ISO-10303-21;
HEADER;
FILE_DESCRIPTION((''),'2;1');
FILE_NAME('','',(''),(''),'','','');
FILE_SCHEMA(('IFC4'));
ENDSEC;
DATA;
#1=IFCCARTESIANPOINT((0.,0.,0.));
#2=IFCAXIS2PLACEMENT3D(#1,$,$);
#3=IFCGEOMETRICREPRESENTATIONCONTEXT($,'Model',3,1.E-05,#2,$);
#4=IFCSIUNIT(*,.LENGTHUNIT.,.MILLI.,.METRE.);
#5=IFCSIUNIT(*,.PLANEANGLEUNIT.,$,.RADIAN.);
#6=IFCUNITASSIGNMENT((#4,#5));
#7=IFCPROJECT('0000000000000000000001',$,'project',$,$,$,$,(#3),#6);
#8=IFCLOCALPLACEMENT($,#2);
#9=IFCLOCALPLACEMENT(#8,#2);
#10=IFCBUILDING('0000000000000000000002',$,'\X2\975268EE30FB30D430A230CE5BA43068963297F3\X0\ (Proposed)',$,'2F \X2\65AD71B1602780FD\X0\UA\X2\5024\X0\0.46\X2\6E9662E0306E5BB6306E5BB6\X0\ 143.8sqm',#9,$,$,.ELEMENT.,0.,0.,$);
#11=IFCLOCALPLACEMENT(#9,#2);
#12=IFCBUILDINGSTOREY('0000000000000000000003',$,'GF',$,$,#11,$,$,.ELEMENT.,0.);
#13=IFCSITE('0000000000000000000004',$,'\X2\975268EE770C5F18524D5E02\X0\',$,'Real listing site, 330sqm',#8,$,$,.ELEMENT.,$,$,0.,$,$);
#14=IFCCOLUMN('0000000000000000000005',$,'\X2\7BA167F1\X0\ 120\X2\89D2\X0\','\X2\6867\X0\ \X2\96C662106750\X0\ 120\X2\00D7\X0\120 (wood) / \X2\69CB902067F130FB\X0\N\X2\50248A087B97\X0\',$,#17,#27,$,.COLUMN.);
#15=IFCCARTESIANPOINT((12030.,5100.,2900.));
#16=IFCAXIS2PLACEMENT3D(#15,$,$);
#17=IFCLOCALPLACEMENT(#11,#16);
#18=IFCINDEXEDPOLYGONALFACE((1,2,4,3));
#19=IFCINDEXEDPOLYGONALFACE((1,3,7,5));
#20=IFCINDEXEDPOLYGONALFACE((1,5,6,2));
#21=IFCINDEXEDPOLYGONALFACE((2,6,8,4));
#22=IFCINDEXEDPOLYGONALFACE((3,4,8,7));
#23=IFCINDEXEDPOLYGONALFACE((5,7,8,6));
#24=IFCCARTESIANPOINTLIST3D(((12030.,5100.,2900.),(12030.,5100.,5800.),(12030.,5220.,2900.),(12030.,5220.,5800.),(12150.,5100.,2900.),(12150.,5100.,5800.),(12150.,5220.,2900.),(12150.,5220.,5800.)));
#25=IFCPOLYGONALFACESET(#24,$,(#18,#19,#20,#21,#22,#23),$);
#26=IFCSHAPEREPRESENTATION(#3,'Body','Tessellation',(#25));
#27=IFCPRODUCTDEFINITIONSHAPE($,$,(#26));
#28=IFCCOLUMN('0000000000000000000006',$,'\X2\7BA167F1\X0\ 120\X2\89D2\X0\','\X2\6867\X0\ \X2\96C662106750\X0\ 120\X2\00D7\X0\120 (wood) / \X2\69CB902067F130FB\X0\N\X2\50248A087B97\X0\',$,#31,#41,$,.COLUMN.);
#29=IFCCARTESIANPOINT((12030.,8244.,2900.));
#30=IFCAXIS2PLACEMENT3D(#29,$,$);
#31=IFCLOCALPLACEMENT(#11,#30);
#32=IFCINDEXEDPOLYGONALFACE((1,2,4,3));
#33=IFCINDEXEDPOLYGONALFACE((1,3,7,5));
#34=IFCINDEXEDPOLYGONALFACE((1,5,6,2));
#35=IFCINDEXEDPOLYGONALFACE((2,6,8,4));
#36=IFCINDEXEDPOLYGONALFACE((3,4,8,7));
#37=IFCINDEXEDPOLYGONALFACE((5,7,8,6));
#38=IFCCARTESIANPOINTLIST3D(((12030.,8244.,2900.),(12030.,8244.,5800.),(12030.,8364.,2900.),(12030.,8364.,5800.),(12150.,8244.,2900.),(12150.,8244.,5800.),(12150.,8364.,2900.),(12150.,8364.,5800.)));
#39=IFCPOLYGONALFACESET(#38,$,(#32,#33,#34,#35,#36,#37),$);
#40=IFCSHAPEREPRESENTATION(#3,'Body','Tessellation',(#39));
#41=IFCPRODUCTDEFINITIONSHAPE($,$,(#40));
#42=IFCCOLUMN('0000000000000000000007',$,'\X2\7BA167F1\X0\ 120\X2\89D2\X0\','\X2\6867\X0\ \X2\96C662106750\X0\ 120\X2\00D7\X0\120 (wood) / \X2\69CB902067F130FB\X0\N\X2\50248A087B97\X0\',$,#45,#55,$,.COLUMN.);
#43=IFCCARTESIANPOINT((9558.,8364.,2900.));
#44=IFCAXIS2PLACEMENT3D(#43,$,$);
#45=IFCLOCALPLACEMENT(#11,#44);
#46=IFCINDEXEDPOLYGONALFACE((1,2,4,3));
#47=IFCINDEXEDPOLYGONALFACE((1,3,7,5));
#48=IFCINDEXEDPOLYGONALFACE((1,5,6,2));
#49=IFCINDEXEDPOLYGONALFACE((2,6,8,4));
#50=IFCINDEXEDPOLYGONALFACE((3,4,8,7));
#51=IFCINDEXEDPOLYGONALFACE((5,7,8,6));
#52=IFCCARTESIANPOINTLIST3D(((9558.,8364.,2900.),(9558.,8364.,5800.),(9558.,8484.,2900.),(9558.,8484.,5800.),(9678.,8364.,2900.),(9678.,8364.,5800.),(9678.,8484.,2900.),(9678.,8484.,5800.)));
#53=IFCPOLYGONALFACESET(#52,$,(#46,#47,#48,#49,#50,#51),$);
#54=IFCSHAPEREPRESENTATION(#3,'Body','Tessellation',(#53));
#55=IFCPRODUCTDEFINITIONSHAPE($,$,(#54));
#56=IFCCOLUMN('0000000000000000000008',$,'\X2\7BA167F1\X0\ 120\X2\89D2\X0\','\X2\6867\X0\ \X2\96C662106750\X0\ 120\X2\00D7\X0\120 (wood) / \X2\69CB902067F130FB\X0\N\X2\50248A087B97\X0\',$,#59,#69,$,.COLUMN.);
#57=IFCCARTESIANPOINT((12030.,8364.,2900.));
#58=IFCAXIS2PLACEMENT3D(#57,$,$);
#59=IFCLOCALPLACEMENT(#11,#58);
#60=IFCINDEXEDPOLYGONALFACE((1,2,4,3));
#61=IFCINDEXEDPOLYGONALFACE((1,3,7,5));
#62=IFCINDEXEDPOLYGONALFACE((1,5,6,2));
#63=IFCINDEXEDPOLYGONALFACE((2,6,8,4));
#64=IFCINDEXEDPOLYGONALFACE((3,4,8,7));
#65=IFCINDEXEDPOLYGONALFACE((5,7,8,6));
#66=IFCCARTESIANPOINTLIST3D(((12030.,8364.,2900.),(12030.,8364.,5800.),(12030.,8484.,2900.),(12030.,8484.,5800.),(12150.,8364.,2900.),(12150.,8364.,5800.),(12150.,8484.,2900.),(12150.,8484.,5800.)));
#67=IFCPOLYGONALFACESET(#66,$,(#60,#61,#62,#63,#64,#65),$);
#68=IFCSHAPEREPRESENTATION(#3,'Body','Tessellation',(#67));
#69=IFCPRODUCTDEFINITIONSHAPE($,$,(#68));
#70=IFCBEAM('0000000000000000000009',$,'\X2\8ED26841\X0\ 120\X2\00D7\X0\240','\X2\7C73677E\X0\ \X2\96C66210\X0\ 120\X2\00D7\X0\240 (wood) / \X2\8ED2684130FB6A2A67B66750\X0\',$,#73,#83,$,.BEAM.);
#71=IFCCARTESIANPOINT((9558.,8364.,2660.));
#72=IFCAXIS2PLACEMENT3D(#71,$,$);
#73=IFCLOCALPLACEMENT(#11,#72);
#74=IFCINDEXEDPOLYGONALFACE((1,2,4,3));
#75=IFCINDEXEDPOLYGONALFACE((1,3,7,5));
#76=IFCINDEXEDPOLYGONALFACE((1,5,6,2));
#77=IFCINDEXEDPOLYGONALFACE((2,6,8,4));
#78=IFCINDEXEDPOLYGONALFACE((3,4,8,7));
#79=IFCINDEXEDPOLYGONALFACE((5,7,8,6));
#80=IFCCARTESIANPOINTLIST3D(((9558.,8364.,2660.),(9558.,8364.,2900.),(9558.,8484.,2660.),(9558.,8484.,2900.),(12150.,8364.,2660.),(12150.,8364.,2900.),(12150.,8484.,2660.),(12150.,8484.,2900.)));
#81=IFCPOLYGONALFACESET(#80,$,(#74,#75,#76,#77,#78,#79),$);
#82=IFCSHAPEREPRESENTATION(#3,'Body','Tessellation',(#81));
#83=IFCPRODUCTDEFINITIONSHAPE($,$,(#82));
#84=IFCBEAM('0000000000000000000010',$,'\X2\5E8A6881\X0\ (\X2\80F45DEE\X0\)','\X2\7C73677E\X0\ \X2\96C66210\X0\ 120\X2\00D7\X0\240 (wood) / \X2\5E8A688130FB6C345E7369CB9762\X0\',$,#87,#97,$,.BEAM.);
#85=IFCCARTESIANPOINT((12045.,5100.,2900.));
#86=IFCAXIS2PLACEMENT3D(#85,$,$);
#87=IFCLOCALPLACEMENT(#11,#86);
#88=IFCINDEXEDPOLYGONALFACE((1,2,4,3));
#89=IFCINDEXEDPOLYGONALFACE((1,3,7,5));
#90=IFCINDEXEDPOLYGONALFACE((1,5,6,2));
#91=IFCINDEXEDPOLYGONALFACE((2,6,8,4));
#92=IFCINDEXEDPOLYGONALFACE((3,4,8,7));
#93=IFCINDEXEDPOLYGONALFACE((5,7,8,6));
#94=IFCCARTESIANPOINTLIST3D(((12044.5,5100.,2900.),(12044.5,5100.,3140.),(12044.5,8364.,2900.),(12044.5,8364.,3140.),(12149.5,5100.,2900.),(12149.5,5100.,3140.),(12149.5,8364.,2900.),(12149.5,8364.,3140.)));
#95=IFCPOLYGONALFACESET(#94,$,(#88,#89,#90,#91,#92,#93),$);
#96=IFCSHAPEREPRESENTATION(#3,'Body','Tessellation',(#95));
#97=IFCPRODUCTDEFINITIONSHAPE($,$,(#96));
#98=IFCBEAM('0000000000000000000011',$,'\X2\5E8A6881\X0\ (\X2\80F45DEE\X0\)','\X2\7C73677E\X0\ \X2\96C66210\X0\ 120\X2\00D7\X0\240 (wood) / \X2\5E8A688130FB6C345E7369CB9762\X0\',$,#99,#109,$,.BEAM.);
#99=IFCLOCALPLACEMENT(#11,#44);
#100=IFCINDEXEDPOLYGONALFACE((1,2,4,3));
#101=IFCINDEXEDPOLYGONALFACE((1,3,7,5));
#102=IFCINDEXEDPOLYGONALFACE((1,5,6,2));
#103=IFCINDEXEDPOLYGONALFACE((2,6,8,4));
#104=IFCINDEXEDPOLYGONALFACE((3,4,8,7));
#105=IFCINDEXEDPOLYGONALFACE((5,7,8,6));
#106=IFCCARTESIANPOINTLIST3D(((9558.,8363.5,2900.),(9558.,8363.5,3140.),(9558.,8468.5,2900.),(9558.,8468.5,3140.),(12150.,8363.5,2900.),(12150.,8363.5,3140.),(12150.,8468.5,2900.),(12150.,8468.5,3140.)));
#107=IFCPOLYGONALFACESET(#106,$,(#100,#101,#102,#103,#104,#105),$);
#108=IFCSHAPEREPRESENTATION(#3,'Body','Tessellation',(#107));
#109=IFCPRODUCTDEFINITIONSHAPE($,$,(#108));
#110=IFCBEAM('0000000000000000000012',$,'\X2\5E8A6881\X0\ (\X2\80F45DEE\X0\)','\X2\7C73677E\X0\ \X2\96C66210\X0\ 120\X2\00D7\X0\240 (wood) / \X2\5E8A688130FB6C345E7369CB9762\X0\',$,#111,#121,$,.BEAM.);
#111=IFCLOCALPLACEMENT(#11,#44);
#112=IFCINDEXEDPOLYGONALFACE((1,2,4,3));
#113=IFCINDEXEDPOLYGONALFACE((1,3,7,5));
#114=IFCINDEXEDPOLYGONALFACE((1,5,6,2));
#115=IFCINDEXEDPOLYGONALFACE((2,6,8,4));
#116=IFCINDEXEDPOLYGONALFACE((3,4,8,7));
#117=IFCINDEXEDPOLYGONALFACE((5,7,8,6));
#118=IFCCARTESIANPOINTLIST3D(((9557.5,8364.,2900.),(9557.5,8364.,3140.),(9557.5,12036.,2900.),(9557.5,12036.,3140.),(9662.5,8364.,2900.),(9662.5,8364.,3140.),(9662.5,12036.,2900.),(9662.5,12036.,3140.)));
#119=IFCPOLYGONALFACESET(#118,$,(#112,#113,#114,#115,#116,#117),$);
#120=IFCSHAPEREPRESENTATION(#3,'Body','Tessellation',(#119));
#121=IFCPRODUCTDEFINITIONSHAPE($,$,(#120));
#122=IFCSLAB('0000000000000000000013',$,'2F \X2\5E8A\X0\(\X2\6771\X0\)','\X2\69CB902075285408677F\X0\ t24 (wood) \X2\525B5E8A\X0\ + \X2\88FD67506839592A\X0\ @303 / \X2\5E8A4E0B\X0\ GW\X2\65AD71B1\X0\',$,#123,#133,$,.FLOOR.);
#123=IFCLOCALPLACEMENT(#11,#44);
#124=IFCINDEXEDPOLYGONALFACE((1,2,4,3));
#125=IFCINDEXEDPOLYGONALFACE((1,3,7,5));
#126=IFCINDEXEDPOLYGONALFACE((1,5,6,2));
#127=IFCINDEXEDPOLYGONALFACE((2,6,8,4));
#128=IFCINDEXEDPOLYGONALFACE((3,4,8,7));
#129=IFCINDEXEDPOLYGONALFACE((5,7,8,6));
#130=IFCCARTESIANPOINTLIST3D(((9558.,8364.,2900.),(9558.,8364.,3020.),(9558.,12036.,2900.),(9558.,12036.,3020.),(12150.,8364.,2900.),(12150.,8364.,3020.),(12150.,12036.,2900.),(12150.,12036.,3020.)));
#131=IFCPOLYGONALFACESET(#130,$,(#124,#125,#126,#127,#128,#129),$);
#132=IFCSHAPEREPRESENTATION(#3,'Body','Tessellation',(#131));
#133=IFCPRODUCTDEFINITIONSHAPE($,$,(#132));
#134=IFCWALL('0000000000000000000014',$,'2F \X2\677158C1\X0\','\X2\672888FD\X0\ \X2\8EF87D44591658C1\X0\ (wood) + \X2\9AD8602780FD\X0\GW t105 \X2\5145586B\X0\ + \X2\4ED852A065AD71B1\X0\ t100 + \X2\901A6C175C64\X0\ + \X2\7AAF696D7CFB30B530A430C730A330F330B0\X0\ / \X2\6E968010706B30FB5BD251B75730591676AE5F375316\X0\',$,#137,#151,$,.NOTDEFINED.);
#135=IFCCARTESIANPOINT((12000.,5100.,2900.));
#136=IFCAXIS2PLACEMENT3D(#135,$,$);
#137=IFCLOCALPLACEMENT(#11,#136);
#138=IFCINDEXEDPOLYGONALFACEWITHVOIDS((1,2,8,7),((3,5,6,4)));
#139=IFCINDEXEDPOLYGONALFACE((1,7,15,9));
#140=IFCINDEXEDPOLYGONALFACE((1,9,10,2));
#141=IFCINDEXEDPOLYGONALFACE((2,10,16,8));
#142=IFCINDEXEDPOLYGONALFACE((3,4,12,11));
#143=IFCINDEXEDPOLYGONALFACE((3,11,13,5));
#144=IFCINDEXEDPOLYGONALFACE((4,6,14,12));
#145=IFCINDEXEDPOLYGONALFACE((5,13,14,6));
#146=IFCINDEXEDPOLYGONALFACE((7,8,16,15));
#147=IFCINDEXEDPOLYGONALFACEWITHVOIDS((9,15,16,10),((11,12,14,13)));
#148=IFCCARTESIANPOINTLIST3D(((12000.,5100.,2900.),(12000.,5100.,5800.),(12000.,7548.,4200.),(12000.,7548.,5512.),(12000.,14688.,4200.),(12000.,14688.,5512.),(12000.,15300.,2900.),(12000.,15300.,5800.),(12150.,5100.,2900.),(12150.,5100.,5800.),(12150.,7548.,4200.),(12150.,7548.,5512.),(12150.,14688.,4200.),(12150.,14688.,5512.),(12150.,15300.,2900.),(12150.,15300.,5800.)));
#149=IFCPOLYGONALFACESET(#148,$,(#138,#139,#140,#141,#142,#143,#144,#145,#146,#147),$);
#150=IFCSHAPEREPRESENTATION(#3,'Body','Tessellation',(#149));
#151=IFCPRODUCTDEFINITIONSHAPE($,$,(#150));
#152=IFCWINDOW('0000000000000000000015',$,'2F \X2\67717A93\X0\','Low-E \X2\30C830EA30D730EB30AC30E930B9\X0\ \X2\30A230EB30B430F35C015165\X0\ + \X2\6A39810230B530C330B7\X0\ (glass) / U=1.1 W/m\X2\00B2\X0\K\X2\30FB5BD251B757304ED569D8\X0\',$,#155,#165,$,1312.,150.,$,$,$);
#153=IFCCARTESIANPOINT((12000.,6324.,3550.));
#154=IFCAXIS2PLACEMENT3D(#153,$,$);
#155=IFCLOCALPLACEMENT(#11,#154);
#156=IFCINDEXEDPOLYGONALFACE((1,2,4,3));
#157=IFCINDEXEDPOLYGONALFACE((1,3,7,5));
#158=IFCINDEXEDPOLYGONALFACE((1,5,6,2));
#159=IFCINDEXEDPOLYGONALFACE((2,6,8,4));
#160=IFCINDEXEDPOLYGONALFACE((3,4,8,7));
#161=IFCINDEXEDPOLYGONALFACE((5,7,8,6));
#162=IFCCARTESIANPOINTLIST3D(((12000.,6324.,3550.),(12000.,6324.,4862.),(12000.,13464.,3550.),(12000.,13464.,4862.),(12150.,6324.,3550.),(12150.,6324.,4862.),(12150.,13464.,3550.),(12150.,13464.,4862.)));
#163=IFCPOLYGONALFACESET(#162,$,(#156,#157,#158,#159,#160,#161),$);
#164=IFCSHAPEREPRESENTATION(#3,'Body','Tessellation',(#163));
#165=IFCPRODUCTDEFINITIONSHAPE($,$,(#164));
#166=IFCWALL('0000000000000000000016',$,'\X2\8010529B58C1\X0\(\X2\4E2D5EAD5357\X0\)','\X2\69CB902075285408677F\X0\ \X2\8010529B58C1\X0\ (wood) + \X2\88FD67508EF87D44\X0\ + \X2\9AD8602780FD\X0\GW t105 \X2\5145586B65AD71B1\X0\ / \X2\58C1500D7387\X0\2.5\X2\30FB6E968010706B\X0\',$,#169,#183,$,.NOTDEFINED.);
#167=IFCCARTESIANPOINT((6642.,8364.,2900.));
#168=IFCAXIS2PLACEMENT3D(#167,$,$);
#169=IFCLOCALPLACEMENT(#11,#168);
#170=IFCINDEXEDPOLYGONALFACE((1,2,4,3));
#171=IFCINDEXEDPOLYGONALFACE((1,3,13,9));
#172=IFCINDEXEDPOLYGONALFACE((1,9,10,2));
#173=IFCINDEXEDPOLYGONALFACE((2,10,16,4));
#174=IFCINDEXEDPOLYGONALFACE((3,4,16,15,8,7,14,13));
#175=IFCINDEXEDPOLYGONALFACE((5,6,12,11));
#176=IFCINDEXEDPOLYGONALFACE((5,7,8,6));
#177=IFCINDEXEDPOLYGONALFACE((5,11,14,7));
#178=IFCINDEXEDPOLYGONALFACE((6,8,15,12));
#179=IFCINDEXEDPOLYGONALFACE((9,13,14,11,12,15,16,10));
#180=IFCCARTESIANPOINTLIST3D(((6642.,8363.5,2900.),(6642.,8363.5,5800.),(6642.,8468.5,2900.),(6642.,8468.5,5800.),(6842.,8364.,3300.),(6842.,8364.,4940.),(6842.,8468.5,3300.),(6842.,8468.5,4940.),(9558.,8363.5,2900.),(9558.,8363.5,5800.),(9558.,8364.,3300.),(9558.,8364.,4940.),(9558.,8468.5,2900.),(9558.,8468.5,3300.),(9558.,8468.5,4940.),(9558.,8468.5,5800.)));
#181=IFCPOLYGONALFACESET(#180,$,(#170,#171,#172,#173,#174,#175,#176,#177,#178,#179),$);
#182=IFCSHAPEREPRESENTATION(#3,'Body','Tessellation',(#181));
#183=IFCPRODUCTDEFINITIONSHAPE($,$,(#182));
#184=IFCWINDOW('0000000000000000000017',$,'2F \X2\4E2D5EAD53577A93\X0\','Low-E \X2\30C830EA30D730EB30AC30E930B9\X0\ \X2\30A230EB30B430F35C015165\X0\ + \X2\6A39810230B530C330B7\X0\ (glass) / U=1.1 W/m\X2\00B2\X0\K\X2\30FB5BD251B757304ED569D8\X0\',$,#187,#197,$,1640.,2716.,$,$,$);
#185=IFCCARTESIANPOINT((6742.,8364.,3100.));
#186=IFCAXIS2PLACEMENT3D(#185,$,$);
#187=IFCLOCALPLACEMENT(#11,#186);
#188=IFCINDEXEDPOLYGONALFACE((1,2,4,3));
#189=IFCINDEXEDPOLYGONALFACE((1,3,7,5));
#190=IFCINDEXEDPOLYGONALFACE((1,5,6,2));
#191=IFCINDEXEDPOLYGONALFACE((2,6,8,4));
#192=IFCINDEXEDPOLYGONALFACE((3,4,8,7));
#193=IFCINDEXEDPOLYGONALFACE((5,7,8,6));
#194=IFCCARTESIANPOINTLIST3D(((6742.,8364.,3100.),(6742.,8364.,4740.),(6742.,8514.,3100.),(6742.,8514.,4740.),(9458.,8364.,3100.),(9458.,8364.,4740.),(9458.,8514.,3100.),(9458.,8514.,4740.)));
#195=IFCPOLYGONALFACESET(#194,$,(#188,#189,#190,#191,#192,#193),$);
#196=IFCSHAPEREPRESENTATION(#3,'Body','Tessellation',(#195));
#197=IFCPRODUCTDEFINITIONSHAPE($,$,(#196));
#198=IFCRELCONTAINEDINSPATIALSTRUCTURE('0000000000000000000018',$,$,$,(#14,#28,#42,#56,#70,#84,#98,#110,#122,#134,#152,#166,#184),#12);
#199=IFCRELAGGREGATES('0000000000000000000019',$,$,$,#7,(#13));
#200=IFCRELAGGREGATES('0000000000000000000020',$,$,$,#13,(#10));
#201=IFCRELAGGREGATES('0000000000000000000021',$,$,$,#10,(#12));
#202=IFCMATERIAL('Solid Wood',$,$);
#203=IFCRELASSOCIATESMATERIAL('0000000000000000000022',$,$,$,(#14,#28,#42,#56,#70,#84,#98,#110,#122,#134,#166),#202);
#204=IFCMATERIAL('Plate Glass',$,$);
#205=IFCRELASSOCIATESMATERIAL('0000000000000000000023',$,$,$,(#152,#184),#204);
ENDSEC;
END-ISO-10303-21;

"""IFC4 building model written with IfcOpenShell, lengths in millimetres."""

from ifc_helpers import new_model, si_unit, frame, frame_2d, origin, place, context, project, spatial, rectangle, extrude, material, element, fill, save


model = new_model("IFC4")

# Units and contexts
model_context = context("Model", 3, precision=1e-05, world=origin())
ifc_project = project(units=[si_unit("LENGTHUNIT", "METRE", prefix="MILLI"), si_unit("PLANEANGLEUNIT", "RADIAN")], contexts=[model_context])

# Site, building, storey
site_placement = place(None, origin())
site = spatial("IfcSite", under=ifc_project, at=site_placement, Name="青森県弘前市", ObjectType="Real listing site, 330sqm", CompositionType="ELEMENT", RefElevation=0.0)
building_placement = place(site_placement, origin())
building = spatial("IfcBuilding", under=site, at=building_placement, Name="青森・ピアノ室と防音 (Proposed)", ObjectType="2F 断熱性能UA値0.46準拠の家の家 143.8sqm", CompositionType="ELEMENT", ElevationOfRefHeight=0.0, ElevationOfTerrain=0.0)
storey_placement = place(building_placement, origin())
storey = spatial("IfcBuildingStorey", under=building, at=storey_placement, Name="GF", CompositionType="ELEMENT", Elevation=0.0)

# Columns
ifc_material_1 = material(Name="Solid Wood")
column_1_placement = place(storey_placement, frame((12030.0, 5100.0, 2900.0)))
element("IfcColumn", 1, at=column_1_placement, inside=storey, material=ifc_material_1, Name="管柱 120角", Description="桧 集成材 120×120 (wood) / 構造柱・N値計算", PredefinedType="COLUMN", context=model_context, shape_type="SweptSolid", body=[
    extrude(rectangle(XDim=120.0, YDim=120.0, at=frame_2d((60.0, 60.0))), frame((12030.0, 5100.0, 2900.0)), (0.0, 0.0, 1.0), 2900.0),
])
column_2_placement = place(storey_placement, frame((12030.0, 8244.0, 2900.0)))
element("IfcColumn", 2, at=column_2_placement, inside=storey, material=ifc_material_1, Name="管柱 120角", Description="桧 集成材 120×120 (wood) / 構造柱・N値計算", PredefinedType="COLUMN", context=model_context, shape_type="SweptSolid", body=[
    extrude(rectangle(XDim=120.0, YDim=120.0, at=frame_2d((60.0, 60.0))), frame((12030.0, 8244.0, 2900.0)), (0.0, 0.0, 1.0), 2900.0),
])
column_3_placement = place(storey_placement, frame((9558.0, 8364.0, 2900.0)))
element("IfcColumn", 3, at=column_3_placement, inside=storey, material=ifc_material_1, Name="管柱 120角", Description="桧 集成材 120×120 (wood) / 構造柱・N値計算", PredefinedType="COLUMN", context=model_context, shape_type="SweptSolid", body=[
    extrude(rectangle(XDim=120.0, YDim=120.0, at=frame_2d((60.0, 60.0))), frame((9558.0, 8364.0, 2900.0)), (0.0, 0.0, 1.0), 2900.0),
])
column_4_placement = place(storey_placement, frame((12030.0, 8364.0, 2900.0)))
element("IfcColumn", 4, at=column_4_placement, inside=storey, material=ifc_material_1, Name="管柱 120角", Description="桧 集成材 120×120 (wood) / 構造柱・N値計算", PredefinedType="COLUMN", context=model_context, shape_type="SweptSolid", body=[
    extrude(rectangle(XDim=120.0, YDim=120.0, at=frame_2d((60.0, 60.0))), frame((12030.0, 8364.0, 2900.0)), (0.0, 0.0, 1.0), 2900.0),
])

# Beams
beam_1_placement = place(storey_placement, frame((9558.0, 8364.0, 2660.0)))
element("IfcBeam", 5, at=beam_1_placement, inside=storey, material=ifc_material_1, Name="軒桁 120×240", Description="米松 集成 120×240 (wood) / 軒桁・横架材", PredefinedType="BEAM", context=model_context, shape_type="SweptSolid", body=[
    extrude(rectangle(XDim=2592.0, YDim=120.0, at=frame_2d((1296.0, 60.0))), frame((9558.0, 8364.0, 2660.0)), (0.0, 0.0, 1.0), 240.0),
])
beam_2_placement = place(storey_placement, frame((12045.0, 5100.0, 2900.0)))
element("IfcBeam", 6, at=beam_2_placement, inside=storey, material=ifc_material_1, Name="床梁 (胴差)", Description="米松 集成 120×240 (wood) / 床梁・水平構面", PredefinedType="BEAM", context=model_context, shape_type="SweptSolid", body=[
    extrude(rectangle(XDim=105.0, YDim=3264.0, at=frame_2d((52.0, 1632.0))), frame((12045.0, 5100.0, 2900.0)), (0.0, 0.0, 1.0), 240.0),
])
beam_3_placement = place(storey_placement, frame((9558.0, 8364.0, 2900.0)))
element("IfcBeam", 7, at=beam_3_placement, inside=storey, material=ifc_material_1, Name="床梁 (胴差)", Description="米松 集成 120×240 (wood) / 床梁・水平構面", PredefinedType="BEAM", context=model_context, shape_type="SweptSolid", body=[
    extrude(rectangle(XDim=2592.0, YDim=105.0, at=frame_2d((1296.0, 52.0))), frame((9558.0, 8364.0, 2900.0)), (0.0, 0.0, 1.0), 240.0),
])
beam_4_placement = place(storey_placement, frame((9558.0, 8364.0, 2900.0)))
element("IfcBeam", 8, at=beam_4_placement, inside=storey, material=ifc_material_1, Name="床梁 (胴差)", Description="米松 集成 120×240 (wood) / 床梁・水平構面", PredefinedType="BEAM", context=model_context, shape_type="SweptSolid", body=[
    extrude(rectangle(XDim=105.0, YDim=3672.0, at=frame_2d((52.0, 1836.0))), frame((9558.0, 8364.0, 2900.0)), (0.0, 0.0, 1.0), 240.0),
])

# Slab
slab_placement = place(storey_placement, frame((9558.0, 8364.0, 2900.0)))
element("IfcSlab", 9, at=slab_placement, inside=storey, material=ifc_material_1, Name="2F 床(東)", Description="構造用合板 t24 (wood) 剛床 + 製材根太 @303 / 床下 GW断熱", PredefinedType="FLOOR", context=model_context, shape_type="SweptSolid", body=[
    extrude(rectangle(XDim=2592.0, YDim=3672.0, at=frame_2d((1296.0, 1836.0))), frame((9558.0, 8364.0, 2900.0)), (0.0, 0.0, 1.0), 120.0),
])

# Walls, openings, windows
wall_1_placement = place(storey_placement, frame((12000.0, 5100.0, 2900.0)))
wall_1 = element("IfcWall", 10, at=wall_1_placement, inside=storey, material=ifc_material_1, Name="2F 東壁", Description="木製 軸組外壁 (wood) + 高性能GW t105 充填 + 付加断熱 t100 + 通気層 + 窯業系サイディング / 準耐火・寒冷地外皮強化", PredefinedType="NOTDEFINED", context=model_context, shape_type="SweptSolid", body=[
    extrude(rectangle(XDim=150.0, YDim=10200.0, at=frame_2d((75.0, 5100.0))), frame((12000.0, 5100.0, 2900.0)), (0.0, 0.0, 1.0), 2900.0),
])
opening_1_placement = place(storey_placement, frame((12000.0, 6324.0, 3550.0)))
opening_1 = element("IfcOpeningElement", 11, at=opening_1_placement, cuts=wall_1, PredefinedType="NOTDEFINED", context=model_context, shape_type="SweptSolid", body=[
    extrude(rectangle(XDim=150.0, YDim=7140.0, at=frame_2d((75.0, 3570.0))), frame((12000.0, 6324.0, 3550.0)), (0.0, 0.0, 1.0), 1312.0),
])
ifc_material_2 = material(Name="Plate Glass")
window_1_placement = place(storey_placement, frame((12000.0, 6324.0, 3550.0)))
window_1 = element("IfcWindow", 12, at=window_1_placement, inside=storey, material=ifc_material_2, Name="2F 東窓", Description="Low-E トリプルガラス アルゴン封入 + 樹脂サッシ (glass) / U=1.1 W/m²K・寒冷地仕様", OverallHeight=1312.0, OverallWidth=150.0, context=model_context, shape_type="SweptSolid", body=[
    extrude(rectangle(XDim=150.0, YDim=7140.0, at=frame_2d((75.0, 3570.0))), frame((12000.0, 6324.0, 3550.0)), (0.0, 0.0, 1.0), 1312.0),
])
fill(opening_1, window_1)
wall_2_placement = place(storey_placement, frame((6642.0, 8364.0, 2900.0)))
wall_2 = element("IfcWall", 13, at=wall_2_placement, inside=storey, material=ifc_material_1, Name="耐力壁(中庭南)", Description="構造用合板 耐力壁 (wood) + 製材軸組 + 高性能GW t105 充填断熱 / 壁倍率2.5・準耐火", PredefinedType="NOTDEFINED", context=model_context, shape_type="SweptSolid", body=[
    extrude(rectangle(XDim=2916.0, YDim=105.0, at=frame_2d((1458.0, 52.0))), frame((6642.0, 8364.0, 2900.0)), (0.0, 0.0, 1.0), 2900.0),
])
opening_2_placement = place(storey_placement, frame((6742.0, 8364.0, 3100.0)))
opening_2 = element("IfcOpeningElement", 14, at=opening_2_placement, cuts=wall_2, PredefinedType="NOTDEFINED", context=model_context, shape_type="SweptSolid", body=[
    extrude(rectangle(XDim=2716.0, YDim=150.0, at=frame_2d((1358.0, 75.0))), frame((6742.0, 8364.0, 3100.0)), (0.0, 0.0, 1.0), 1640.0),
])
window_2_placement = place(storey_placement, frame((6742.0, 8364.0, 3100.0)))
window_2 = element("IfcWindow", 15, at=window_2_placement, inside=storey, material=ifc_material_2, Name="2F 中庭南窓", Description="Low-E トリプルガラス アルゴン封入 + 樹脂サッシ (glass) / U=1.1 W/m²K・寒冷地仕様", OverallHeight=1640.0, OverallWidth=2716.0, context=model_context, shape_type="SweptSolid", body=[
    extrude(rectangle(XDim=2716.0, YDim=150.0, at=frame_2d((1358.0, 75.0))), frame((6742.0, 8364.0, 3100.0)), (0.0, 0.0, 1.0), 1640.0),
])
fill(opening_2, window_2)

save(model, "model.ifc")
